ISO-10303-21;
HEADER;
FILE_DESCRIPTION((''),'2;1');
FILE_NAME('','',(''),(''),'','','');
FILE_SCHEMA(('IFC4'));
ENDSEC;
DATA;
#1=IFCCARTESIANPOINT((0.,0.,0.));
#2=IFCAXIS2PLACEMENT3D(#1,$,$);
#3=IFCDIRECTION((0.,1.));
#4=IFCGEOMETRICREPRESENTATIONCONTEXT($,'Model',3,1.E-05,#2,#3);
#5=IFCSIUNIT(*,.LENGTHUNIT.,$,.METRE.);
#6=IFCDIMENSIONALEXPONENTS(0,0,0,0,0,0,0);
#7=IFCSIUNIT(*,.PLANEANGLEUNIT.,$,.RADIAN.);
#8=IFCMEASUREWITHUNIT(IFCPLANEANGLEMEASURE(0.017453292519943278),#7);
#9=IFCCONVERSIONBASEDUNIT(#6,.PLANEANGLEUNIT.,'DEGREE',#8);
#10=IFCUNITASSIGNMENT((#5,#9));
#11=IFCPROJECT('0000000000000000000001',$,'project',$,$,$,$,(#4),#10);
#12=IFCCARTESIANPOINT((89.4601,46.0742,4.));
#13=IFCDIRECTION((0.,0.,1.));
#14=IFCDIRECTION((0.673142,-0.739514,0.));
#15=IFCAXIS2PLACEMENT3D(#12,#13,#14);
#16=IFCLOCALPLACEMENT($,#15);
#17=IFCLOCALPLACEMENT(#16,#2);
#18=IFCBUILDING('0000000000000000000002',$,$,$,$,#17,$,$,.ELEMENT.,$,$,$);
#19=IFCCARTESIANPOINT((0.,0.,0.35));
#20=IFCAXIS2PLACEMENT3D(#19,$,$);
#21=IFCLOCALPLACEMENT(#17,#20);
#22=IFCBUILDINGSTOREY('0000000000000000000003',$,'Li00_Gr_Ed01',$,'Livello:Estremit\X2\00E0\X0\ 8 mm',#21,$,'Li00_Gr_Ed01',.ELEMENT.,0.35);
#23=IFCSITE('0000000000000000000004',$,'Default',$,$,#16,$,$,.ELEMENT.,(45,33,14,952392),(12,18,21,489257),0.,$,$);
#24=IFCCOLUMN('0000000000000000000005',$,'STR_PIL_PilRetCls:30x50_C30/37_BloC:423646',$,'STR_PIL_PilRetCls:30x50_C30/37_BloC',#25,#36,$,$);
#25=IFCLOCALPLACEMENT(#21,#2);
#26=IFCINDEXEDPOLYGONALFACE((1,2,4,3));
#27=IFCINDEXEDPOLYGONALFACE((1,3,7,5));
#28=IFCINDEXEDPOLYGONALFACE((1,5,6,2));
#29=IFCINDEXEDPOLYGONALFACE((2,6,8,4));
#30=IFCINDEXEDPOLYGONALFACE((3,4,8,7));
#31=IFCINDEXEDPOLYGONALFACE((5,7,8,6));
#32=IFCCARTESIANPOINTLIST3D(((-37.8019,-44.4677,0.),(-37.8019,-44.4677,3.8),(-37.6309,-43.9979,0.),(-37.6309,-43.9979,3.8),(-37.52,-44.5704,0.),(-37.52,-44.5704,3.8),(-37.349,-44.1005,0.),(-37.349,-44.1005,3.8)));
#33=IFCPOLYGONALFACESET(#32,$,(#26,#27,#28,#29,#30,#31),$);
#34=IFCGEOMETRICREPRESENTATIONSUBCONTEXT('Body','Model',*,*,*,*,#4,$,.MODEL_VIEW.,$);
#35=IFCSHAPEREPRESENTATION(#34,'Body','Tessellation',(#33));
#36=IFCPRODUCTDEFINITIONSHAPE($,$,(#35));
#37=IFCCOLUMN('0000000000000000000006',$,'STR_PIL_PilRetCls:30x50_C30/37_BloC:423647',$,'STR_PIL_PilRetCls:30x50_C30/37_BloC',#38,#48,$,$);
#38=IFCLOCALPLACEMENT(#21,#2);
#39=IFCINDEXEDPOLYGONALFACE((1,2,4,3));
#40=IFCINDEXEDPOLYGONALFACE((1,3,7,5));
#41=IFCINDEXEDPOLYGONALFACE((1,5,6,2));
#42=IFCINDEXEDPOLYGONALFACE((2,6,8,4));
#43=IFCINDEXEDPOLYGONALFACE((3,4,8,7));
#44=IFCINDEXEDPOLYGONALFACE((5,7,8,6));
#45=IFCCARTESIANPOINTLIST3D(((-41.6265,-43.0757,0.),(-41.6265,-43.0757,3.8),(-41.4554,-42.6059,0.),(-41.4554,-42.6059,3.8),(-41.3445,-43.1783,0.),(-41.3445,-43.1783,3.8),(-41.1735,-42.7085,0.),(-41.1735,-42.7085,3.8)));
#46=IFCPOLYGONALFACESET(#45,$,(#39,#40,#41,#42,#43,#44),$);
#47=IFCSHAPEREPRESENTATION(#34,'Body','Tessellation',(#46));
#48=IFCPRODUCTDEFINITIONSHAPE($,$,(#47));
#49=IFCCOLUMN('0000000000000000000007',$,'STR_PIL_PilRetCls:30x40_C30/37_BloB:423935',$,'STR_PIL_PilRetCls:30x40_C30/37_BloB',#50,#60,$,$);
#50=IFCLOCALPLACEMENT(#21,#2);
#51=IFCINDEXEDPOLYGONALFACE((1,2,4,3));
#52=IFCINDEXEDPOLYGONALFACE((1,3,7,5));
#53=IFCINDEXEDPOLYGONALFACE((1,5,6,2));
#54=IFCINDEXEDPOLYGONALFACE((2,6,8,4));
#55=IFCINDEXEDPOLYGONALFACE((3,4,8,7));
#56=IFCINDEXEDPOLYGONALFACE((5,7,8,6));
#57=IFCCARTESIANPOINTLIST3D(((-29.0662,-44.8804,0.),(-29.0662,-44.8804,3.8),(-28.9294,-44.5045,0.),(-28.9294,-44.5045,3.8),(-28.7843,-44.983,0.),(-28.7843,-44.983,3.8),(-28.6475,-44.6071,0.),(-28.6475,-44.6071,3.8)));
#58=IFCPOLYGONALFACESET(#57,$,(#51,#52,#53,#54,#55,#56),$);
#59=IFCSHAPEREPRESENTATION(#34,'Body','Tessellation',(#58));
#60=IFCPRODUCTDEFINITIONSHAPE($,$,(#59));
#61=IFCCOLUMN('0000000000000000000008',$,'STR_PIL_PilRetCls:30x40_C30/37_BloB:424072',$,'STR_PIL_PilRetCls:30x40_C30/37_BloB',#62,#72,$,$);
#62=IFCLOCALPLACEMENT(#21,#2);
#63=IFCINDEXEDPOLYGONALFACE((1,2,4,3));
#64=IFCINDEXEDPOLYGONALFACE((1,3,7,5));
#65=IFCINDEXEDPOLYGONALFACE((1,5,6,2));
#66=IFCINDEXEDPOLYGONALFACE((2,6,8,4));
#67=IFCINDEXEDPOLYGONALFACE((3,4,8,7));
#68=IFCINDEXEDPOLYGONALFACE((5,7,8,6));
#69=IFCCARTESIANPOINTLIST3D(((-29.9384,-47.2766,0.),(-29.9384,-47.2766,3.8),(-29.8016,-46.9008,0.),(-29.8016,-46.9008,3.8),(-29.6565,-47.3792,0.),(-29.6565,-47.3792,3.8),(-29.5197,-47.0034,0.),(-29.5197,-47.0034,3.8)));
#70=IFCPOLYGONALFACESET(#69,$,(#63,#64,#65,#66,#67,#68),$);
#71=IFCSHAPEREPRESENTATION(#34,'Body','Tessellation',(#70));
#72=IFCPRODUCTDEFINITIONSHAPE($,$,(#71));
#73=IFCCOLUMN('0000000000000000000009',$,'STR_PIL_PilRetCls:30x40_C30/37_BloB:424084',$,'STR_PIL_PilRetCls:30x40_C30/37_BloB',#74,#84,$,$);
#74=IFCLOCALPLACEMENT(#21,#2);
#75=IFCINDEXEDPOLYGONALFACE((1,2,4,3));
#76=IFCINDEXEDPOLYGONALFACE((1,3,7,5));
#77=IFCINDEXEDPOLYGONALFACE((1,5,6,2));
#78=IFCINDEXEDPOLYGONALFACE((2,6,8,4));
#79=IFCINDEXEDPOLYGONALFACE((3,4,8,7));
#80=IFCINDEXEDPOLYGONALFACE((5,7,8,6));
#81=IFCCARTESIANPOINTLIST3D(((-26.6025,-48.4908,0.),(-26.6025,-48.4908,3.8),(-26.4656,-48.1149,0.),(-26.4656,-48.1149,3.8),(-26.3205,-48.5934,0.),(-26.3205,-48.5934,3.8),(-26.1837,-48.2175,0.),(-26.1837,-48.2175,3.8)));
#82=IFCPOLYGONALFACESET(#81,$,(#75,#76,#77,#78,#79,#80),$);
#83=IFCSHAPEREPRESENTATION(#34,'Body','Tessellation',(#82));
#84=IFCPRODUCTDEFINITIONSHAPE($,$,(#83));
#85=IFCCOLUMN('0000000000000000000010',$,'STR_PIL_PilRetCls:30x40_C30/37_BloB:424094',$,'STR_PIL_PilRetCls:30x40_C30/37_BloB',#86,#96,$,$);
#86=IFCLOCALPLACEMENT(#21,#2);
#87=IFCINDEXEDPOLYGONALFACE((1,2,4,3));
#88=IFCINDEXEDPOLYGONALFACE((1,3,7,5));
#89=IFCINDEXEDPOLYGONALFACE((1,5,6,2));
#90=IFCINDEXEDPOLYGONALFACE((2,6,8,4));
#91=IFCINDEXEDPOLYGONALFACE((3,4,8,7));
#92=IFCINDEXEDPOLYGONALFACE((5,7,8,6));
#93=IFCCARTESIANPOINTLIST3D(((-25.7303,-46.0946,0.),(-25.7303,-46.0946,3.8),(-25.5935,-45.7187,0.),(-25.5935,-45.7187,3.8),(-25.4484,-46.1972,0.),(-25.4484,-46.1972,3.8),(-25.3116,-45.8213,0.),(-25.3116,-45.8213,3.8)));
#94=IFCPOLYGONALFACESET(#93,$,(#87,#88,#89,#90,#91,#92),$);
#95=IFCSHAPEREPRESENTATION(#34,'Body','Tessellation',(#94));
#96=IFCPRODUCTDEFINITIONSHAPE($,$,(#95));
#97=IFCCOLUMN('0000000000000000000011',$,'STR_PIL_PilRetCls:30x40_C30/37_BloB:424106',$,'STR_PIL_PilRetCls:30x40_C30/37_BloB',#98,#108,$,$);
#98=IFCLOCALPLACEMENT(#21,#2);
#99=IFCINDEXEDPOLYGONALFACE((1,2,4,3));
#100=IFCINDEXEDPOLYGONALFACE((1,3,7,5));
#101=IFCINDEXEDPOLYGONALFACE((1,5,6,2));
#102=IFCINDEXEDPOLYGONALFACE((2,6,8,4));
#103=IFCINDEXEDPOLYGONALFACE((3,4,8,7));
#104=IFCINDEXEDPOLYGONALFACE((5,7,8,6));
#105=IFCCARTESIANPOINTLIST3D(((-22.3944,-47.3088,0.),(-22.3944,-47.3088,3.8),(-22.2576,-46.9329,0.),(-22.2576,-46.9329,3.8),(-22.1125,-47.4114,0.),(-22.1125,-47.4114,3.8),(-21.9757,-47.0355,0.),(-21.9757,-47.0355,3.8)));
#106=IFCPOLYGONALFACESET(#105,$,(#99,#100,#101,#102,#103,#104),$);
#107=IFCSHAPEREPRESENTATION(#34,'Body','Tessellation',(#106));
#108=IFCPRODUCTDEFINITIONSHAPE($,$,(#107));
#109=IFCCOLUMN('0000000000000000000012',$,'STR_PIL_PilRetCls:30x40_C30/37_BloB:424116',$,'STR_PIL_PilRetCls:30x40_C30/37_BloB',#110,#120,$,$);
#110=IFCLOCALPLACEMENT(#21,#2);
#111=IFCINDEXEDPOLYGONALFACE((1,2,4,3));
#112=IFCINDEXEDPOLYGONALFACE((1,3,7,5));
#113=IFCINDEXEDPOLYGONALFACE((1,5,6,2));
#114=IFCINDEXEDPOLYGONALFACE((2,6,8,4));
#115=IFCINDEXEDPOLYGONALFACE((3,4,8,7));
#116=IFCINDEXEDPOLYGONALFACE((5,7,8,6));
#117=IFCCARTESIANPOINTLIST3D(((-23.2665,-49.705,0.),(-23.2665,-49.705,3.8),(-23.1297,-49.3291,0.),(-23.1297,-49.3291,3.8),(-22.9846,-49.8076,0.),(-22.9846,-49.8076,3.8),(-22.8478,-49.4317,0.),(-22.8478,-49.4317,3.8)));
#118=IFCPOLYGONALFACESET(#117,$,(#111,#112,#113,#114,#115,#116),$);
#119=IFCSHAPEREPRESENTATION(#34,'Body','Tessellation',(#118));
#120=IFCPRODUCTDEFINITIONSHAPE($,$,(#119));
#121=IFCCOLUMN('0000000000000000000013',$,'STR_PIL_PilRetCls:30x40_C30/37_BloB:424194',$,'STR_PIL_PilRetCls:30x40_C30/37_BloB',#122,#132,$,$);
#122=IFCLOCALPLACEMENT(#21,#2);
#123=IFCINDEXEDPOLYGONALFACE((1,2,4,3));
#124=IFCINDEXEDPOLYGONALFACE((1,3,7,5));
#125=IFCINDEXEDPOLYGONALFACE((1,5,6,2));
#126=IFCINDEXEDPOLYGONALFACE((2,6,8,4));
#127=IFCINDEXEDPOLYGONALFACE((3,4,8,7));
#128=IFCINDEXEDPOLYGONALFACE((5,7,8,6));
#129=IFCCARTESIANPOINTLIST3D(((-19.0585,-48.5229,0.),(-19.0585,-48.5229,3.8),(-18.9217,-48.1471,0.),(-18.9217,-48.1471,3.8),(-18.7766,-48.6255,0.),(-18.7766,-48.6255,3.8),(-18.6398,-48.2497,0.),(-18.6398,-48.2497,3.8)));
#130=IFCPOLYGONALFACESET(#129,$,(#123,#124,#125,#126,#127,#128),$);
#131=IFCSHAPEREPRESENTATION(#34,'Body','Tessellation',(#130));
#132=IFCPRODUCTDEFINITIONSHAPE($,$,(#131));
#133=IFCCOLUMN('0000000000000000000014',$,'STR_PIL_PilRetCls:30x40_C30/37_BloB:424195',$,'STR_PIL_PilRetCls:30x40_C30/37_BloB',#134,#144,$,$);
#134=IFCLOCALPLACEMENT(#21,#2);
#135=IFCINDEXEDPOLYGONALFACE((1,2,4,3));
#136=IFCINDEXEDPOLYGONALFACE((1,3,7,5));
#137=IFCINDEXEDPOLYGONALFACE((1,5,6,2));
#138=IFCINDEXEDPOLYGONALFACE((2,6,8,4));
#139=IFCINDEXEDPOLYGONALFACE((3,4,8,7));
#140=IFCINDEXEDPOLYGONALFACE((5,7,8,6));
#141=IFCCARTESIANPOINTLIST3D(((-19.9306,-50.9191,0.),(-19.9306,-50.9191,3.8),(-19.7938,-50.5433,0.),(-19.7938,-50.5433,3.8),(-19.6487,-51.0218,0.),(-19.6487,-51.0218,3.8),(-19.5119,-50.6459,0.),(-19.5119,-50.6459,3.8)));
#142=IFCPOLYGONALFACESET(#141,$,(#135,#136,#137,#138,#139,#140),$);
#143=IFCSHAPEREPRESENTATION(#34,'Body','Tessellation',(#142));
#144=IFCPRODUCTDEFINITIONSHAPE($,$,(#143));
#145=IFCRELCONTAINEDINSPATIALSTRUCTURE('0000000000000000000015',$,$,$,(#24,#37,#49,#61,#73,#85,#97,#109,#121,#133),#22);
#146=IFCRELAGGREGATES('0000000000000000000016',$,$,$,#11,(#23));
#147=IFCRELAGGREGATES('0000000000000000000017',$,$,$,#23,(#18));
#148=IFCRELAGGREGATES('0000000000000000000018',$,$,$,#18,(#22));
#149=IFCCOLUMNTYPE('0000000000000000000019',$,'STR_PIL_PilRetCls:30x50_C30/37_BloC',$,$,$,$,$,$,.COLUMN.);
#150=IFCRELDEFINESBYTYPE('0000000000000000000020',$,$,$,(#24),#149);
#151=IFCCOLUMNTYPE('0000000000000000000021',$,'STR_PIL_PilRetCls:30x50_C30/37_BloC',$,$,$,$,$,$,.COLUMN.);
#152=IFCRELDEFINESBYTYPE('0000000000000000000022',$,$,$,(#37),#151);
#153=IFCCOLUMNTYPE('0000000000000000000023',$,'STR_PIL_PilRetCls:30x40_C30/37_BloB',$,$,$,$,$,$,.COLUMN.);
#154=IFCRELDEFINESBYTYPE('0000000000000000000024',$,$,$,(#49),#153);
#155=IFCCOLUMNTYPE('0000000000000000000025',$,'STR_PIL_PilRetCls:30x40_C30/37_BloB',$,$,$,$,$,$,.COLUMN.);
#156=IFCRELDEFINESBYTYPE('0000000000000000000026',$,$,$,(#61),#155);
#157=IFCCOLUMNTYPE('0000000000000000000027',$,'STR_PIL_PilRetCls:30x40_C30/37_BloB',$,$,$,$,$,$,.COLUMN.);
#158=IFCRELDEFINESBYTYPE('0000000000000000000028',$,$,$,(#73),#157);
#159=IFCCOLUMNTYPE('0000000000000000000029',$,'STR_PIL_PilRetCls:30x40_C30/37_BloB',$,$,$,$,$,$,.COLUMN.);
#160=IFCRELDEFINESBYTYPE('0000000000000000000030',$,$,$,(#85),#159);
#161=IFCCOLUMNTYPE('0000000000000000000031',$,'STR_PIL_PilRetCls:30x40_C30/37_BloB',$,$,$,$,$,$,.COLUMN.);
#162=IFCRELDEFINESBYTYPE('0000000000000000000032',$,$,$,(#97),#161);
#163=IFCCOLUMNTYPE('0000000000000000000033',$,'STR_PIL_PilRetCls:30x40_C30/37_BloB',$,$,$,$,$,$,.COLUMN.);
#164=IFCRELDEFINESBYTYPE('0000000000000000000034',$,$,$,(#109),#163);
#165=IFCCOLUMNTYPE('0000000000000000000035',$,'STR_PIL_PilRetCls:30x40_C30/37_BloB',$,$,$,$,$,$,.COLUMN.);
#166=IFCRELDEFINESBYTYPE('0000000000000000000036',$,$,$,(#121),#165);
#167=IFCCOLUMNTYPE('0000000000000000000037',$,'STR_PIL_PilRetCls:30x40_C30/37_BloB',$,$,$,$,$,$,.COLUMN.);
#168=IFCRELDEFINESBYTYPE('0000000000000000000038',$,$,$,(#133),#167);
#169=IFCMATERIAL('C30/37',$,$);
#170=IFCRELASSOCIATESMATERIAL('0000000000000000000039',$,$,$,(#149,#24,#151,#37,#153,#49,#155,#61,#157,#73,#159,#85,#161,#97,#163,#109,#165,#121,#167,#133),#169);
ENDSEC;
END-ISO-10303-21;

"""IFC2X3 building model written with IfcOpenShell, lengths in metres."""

from ifc_helpers import new_model, entity, si_unit, converted_unit, direction, frame, frame_2d, origin, origin_2d_with_axis, place, context, subcontext, project, spatial, rectangle, extrude, source, transform, mapped, material, type_object, type_shapes, element, save


model = new_model("IFC2X3")

# Units and contexts
model_context = context("Model", 3, precision=1e-05, world=origin(), true_north=direction((0.0, 1.0)))
body_context = subcontext(model_context, "Body", "Model", "MODEL_VIEW")
ifc_project = project(units=[si_unit("LENGTHUNIT", "METRE"), converted_unit("PLANEANGLEUNIT", "DEGREE", entity("IfcPlaneAngleMeasure", 0.017453292519943278), si_unit("PLANEANGLEUNIT", "RADIAN"), dimensions=[0, 0, 0, 0, 0, 0, 0])], contexts=[model_context])

# Site, building, storey
site_placement = place(None, frame((89.4601, 46.0742, 4.0), z_axis=(0.0, 0.0, 1.0), x_axis=(0.673142, -0.739514, 0.0)))
site = spatial("IfcSite", under=ifc_project, at=site_placement, Name="Default", CompositionType="ELEMENT", RefLatitude=(45, 33, 14, 952392), RefLongitude=(12, 18, 21, 489257), RefElevation=0.0)
building_placement = place(site_placement, origin())
building = spatial("IfcBuilding", under=site, at=building_placement, CompositionType="ELEMENT")
storey_placement = place(building_placement, frame((0.0, 0.0, 0.35)))
storey = spatial("IfcBuildingStorey", under=building, at=storey_placement, Name="Li00_Gr_Ed01", ObjectType="Livello:Estremità 8 mm", LongName="Li00_Gr_Ed01", CompositionType="ELEMENT", Elevation=0.35)

# Columns
ifc_material_1 = material(Name="C30/37")
column_type_1 = type_object("IfcColumnType", Name="STR_PIL_PilRetCls:30x50_C30/37_BloC", PredefinedType="COLUMN", material=ifc_material_1)
shared_shape_1 = source(origin(), body_context, "Body", "SweptSolid", [
    extrude(rectangle(XDim=0.3, YDim=0.5, at=origin_2d_with_axis()), frame((-37.5754, -44.2841, 0.35), z_axis=(0.0, 0.0, 1.0), x_axis=(-0.939693, 0.34202, 0.0)), (0.0, 0.0, 1.0), 3.8),
])
type_shapes(column_type_1, [shared_shape_1])
column_1_placement = place(storey_placement, frame((0.0, 0.0, -0.35)))
element("IfcColumn", 1, at=column_1_placement, inside=storey, type_object=column_type_1, material=ifc_material_1, Name="STR_PIL_PilRetCls:30x50_C30/37_BloC:423646", ObjectType="STR_PIL_PilRetCls:30x50_C30/37_BloC", context=body_context, shape_type="MappedRepresentation", body=[
    mapped(shared_shape_1, transform((0.0, 0.0, 0.0), scale=1.0)),
])
column_type_2 = type_object("IfcColumnType", Name="STR_PIL_PilRetCls:30x50_C30/37_BloC", PredefinedType="COLUMN", material=ifc_material_1)
shared_shape_2 = source(origin(), body_context, "Body", "SweptSolid", [
    extrude(rectangle(XDim=0.3, YDim=0.5, at=frame_2d((0.0, 0.0), x_axis=(1.0, 0.0))), frame((-41.4, -42.8921, 0.35), z_axis=(0.0, 0.0, 1.0), x_axis=(-0.939693, 0.34202, 0.0)), (0.0, 0.0, 1.0), 3.8),
])
type_shapes(column_type_2, [shared_shape_2])
column_2_placement = place(storey_placement, frame((0.0, 0.0, -0.35)))
element("IfcColumn", 2, at=column_2_placement, inside=storey, type_object=column_type_2, material=ifc_material_1, Name="STR_PIL_PilRetCls:30x50_C30/37_BloC:423647", ObjectType="STR_PIL_PilRetCls:30x50_C30/37_BloC", context=body_context, shape_type="MappedRepresentation", body=[
    mapped(shared_shape_2, transform((0.0, 0.0, 0.0), scale=1.0)),
])
column_type_3 = type_object("IfcColumnType", Name="STR_PIL_PilRetCls:30x40_C30/37_BloB", PredefinedType="COLUMN", material=ifc_material_1)
shared_shape_3 = source(origin(), body_context, "Body", "SweptSolid", [
    extrude(rectangle(XDim=0.3, YDim=0.4, at=frame_2d((0.0, 0.0), x_axis=(1.0, 0.0))), frame((-28.8569, -44.7438, 0.35), z_axis=(0.0, 0.0, 1.0), x_axis=(0.939693, -0.34202, 0.0)), (0.0, 0.0, 1.0), 3.8),
])
type_shapes(column_type_3, [shared_shape_3])
column_3_placement = place(storey_placement, frame((0.0, 0.0, -0.35)))
element("IfcColumn", 3, at=column_3_placement, inside=storey, type_object=column_type_3, material=ifc_material_1, Name="STR_PIL_PilRetCls:30x40_C30/37_BloB:423935", ObjectType="STR_PIL_PilRetCls:30x40_C30/37_BloB", context=body_context, shape_type="MappedRepresentation", body=[
    mapped(shared_shape_3, transform((0.0, 0.0, 0.0), scale=1.0)),
])
column_type_4 = type_object("IfcColumnType", Name="STR_PIL_PilRetCls:30x40_C30/37_BloB", PredefinedType="COLUMN", material=ifc_material_1)
shared_shape_4 = source(origin(), body_context, "Body", "SweptSolid", [
    extrude(rectangle(XDim=0.3, YDim=0.4, at=frame_2d((0.0, 0.0), x_axis=(1.0, 0.0))), frame((-29.729, -47.14, 0.35), z_axis=(0.0, 0.0, 1.0), x_axis=(0.939693, -0.34202, 0.0)), (0.0, 0.0, 1.0), 3.8),
])
type_shapes(column_type_4, [shared_shape_4])
column_4_placement = place(storey_placement, frame((0.0, 0.0, -0.35)))
element("IfcColumn", 4, at=column_4_placement, inside=storey, type_object=column_type_4, material=ifc_material_1, Name="STR_PIL_PilRetCls:30x40_C30/37_BloB:424072", ObjectType="STR_PIL_PilRetCls:30x40_C30/37_BloB", context=body_context, shape_type="MappedRepresentation", body=[
    mapped(shared_shape_4, transform((0.0, 0.0, 0.0), scale=1.0)),
])
column_type_5 = type_object("IfcColumnType", Name="STR_PIL_PilRetCls:30x40_C30/37_BloB", PredefinedType="COLUMN", material=ifc_material_1)
shared_shape_5 = source(origin(), body_context, "Body", "SweptSolid", [
    extrude(rectangle(XDim=0.3, YDim=0.4, at=frame_2d((0.0, 0.0), x_axis=(1.0, 0.0))), frame((-26.3931, -48.3542, 0.35), z_axis=(0.0, 0.0, 1.0), x_axis=(0.939693, -0.34202, 0.0)), (0.0, 0.0, 1.0), 3.8),
])
type_shapes(column_type_5, [shared_shape_5])
column_5_placement = place(storey_placement, frame((0.0, 0.0, -0.35)))
element("IfcColumn", 5, at=column_5_placement, inside=storey, type_object=column_type_5, material=ifc_material_1, Name="STR_PIL_PilRetCls:30x40_C30/37_BloB:424084", ObjectType="STR_PIL_PilRetCls:30x40_C30/37_BloB", context=body_context, shape_type="MappedRepresentation", body=[
    mapped(shared_shape_5, transform((0.0, 0.0, 0.0), scale=1.0)),
])
column_type_6 = type_object("IfcColumnType", Name="STR_PIL_PilRetCls:30x40_C30/37_BloB", PredefinedType="COLUMN", material=ifc_material_1)
shared_shape_6 = source(origin(), body_context, "Body", "SweptSolid", [
    extrude(rectangle(XDim=0.3, YDim=0.4, at=frame_2d((0.0, 0.0), x_axis=(1.0, 0.0))), frame((-25.5209, -45.958, 0.35), z_axis=(0.0, 0.0, 1.0), x_axis=(0.939693, -0.34202, 0.0)), (0.0, 0.0, 1.0), 3.8),
])
type_shapes(column_type_6, [shared_shape_6])
column_6_placement = place(storey_placement, frame((0.0, 0.0, -0.35)))
element("IfcColumn", 6, at=column_6_placement, inside=storey, type_object=column_type_6, material=ifc_material_1, Name="STR_PIL_PilRetCls:30x40_C30/37_BloB:424094", ObjectType="STR_PIL_PilRetCls:30x40_C30/37_BloB", context=body_context, shape_type="MappedRepresentation", body=[
    mapped(shared_shape_6, transform((0.0, 0.0, 0.0), scale=1.0)),
])
column_type_7 = type_object("IfcColumnType", Name="STR_PIL_PilRetCls:30x40_C30/37_BloB", PredefinedType="COLUMN", material=ifc_material_1)
shared_shape_7 = source(origin(), body_context, "Body", "SweptSolid", [
    extrude(rectangle(XDim=0.3, YDim=0.4, at=frame_2d((0.0, 0.0), x_axis=(1.0, 0.0))), frame((-22.185, -47.1721, 0.35), z_axis=(0.0, 0.0, 1.0), x_axis=(0.939693, -0.34202, 0.0)), (0.0, 0.0, 1.0), 3.8),
])
type_shapes(column_type_7, [shared_shape_7])
column_7_placement = place(storey_placement, frame((0.0, 0.0, -0.35)))
element("IfcColumn", 7, at=column_7_placement, inside=storey, type_object=column_type_7, material=ifc_material_1, Name="STR_PIL_PilRetCls:30x40_C30/37_BloB:424106", ObjectType="STR_PIL_PilRetCls:30x40_C30/37_BloB", context=body_context, shape_type="MappedRepresentation", body=[
    mapped(shared_shape_7, transform((0.0, 0.0, 0.0), scale=1.0)),
])
column_type_8 = type_object("IfcColumnType", Name="STR_PIL_PilRetCls:30x40_C30/37_BloB", PredefinedType="COLUMN", material=ifc_material_1)
shared_shape_8 = source(origin(), body_context, "Body", "SweptSolid", [
    extrude(rectangle(XDim=0.3, YDim=0.4, at=frame_2d((0.0, 0.0), x_axis=(1.0, 0.0))), frame((-23.0572, -49.5683, 0.35), z_axis=(0.0, 0.0, 1.0), x_axis=(0.939693, -0.34202, 0.0)), (0.0, 0.0, 1.0), 3.8),
])
type_shapes(column_type_8, [shared_shape_8])
column_8_placement = place(storey_placement, frame((0.0, 0.0, -0.35)))
element("IfcColumn", 8, at=column_8_placement, inside=storey, type_object=column_type_8, material=ifc_material_1, Name="STR_PIL_PilRetCls:30x40_C30/37_BloB:424116", ObjectType="STR_PIL_PilRetCls:30x40_C30/37_BloB", context=body_context, shape_type="MappedRepresentation", body=[
    mapped(shared_shape_8, transform((0.0, 0.0, 0.0), scale=1.0)),
])
column_type_9 = type_object("IfcColumnType", Name="STR_PIL_PilRetCls:30x40_C30/37_BloB", PredefinedType="COLUMN", material=ifc_material_1)
shared_shape_9 = source(origin(), body_context, "Body", "SweptSolid", [
    extrude(rectangle(XDim=0.3, YDim=0.4, at=frame_2d((0.0, 0.0), x_axis=(1.0, 0.0))), frame((-18.8491, -48.3863, 0.35), z_axis=(0.0, 0.0, 1.0), x_axis=(0.939693, -0.34202, 0.0)), (0.0, 0.0, 1.0), 3.8),
])
type_shapes(column_type_9, [shared_shape_9])
column_9_placement = place(storey_placement, frame((0.0, 0.0, -0.35)))
element("IfcColumn", 9, at=column_9_placement, inside=storey, type_object=column_type_9, material=ifc_material_1, Name="STR_PIL_PilRetCls:30x40_C30/37_BloB:424194", ObjectType="STR_PIL_PilRetCls:30x40_C30/37_BloB", context=body_context, shape_type="MappedRepresentation", body=[
    mapped(shared_shape_9, transform((0.0, 0.0, 0.0), scale=1.0)),
])
column_type_10 = type_object("IfcColumnType", Name="STR_PIL_PilRetCls:30x40_C30/37_BloB", PredefinedType="COLUMN", material=ifc_material_1)
shared_shape_10 = source(origin(), body_context, "Body", "SweptSolid", [
    extrude(rectangle(XDim=0.3, YDim=0.4, at=frame_2d((0.0, 0.0), x_axis=(1.0, 0.0))), frame((-19.7213, -50.7825, 0.35), z_axis=(0.0, 0.0, 1.0), x_axis=(0.939693, -0.34202, 0.0)), (0.0, 0.0, 1.0), 3.8),
])
type_shapes(column_type_10, [shared_shape_10])
column_10_placement = place(storey_placement, frame((0.0, 0.0, -0.35)))
element("IfcColumn", 10, at=column_10_placement, inside=storey, type_object=column_type_10, material=ifc_material_1, Name="STR_PIL_PilRetCls:30x40_C30/37_BloB:424195", ObjectType="STR_PIL_PilRetCls:30x40_C30/37_BloB", context=body_context, shape_type="MappedRepresentation", body=[
    mapped(shared_shape_10, transform((0.0, 0.0, 0.0), scale=1.0)),
])

save(model, "model.ifc")
